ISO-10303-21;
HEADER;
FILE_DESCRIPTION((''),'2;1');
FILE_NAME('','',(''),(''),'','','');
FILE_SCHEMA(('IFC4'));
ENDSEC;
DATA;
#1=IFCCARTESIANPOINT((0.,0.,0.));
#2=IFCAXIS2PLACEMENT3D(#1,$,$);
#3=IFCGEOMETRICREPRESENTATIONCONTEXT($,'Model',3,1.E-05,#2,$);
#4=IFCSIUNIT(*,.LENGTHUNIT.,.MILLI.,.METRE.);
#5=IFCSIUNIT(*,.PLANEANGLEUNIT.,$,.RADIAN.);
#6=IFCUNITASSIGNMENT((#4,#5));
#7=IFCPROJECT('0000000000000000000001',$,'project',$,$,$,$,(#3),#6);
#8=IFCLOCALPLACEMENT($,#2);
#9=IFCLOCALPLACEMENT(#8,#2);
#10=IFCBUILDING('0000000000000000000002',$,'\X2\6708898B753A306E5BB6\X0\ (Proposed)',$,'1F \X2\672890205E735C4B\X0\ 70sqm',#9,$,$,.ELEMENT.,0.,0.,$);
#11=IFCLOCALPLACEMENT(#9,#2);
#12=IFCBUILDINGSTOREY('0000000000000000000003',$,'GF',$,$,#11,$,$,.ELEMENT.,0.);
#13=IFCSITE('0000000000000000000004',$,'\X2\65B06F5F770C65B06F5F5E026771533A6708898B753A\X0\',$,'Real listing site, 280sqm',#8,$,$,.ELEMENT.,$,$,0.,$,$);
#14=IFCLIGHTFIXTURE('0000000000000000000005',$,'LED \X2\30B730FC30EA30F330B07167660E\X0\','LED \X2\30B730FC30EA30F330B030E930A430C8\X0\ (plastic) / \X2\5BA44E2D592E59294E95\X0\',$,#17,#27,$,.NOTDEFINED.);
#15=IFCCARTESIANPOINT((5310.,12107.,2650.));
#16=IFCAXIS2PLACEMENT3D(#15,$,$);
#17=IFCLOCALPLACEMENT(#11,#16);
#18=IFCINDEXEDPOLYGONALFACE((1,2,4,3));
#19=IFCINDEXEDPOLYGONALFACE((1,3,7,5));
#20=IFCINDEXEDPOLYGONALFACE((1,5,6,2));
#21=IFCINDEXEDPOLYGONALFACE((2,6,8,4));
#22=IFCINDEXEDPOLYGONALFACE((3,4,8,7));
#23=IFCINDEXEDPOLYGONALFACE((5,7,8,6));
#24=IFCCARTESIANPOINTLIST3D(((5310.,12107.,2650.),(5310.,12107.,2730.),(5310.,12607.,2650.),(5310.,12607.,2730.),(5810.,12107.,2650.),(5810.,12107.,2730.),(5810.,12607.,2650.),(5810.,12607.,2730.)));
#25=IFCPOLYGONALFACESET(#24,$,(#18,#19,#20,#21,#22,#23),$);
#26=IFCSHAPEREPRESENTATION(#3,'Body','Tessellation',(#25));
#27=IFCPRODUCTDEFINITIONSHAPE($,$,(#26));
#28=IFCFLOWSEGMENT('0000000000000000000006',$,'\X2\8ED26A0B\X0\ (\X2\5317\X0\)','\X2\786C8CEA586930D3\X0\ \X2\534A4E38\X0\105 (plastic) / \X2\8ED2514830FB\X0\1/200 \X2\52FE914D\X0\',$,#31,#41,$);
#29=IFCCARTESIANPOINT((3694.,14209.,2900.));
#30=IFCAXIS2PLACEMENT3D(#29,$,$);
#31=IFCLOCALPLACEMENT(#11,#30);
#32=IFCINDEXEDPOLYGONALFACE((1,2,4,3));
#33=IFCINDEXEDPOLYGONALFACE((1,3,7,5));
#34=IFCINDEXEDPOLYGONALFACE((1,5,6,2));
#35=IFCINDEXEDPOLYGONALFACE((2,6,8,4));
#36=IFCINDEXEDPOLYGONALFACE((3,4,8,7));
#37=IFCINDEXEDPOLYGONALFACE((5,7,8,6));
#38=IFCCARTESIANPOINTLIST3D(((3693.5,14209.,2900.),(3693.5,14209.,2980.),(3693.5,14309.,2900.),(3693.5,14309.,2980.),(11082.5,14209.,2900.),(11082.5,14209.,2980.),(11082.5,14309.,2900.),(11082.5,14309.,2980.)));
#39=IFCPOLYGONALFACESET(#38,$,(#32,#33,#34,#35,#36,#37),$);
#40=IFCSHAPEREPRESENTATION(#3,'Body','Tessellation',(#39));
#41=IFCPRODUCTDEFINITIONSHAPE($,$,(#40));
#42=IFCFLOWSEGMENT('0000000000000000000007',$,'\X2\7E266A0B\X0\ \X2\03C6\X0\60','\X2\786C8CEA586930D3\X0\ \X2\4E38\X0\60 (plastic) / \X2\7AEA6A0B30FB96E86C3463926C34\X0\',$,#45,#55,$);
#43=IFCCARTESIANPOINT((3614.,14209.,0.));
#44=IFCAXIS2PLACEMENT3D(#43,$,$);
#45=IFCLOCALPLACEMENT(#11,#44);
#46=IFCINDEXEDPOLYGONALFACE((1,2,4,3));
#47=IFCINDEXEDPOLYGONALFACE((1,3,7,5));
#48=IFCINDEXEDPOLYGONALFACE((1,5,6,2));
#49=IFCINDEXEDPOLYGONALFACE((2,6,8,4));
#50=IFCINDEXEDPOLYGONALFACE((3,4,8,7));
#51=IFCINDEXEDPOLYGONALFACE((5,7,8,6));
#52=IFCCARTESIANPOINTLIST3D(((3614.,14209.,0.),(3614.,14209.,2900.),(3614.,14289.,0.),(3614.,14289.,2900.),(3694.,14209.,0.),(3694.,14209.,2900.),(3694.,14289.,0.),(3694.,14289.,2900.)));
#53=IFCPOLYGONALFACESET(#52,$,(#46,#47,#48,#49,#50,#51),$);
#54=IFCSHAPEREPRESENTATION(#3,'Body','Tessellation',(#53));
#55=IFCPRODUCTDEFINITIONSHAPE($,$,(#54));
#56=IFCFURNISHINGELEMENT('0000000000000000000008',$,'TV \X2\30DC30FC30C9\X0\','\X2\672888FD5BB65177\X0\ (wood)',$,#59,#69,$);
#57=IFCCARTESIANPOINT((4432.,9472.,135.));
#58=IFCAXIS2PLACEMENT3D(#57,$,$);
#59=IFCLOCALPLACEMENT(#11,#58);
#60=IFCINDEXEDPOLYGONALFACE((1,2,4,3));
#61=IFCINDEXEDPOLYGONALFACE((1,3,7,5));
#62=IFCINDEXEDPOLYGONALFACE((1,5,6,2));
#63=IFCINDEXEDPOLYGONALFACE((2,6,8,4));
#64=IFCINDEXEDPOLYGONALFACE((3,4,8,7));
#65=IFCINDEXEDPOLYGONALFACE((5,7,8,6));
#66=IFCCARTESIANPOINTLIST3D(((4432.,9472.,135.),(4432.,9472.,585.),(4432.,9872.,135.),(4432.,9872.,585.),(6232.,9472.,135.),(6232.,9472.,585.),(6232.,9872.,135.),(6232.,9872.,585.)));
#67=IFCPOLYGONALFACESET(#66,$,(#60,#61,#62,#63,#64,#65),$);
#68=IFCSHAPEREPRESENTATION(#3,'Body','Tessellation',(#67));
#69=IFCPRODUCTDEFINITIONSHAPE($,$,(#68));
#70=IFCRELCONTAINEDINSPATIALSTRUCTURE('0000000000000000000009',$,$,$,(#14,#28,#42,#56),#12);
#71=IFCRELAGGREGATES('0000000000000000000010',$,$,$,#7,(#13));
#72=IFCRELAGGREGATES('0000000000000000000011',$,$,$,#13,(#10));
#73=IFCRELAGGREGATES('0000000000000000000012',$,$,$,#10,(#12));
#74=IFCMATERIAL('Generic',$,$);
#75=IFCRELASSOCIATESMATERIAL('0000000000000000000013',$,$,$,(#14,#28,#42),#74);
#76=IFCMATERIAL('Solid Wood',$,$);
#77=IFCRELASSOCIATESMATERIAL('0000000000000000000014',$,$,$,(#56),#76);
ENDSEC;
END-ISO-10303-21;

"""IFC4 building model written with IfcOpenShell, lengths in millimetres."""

from ifc_helpers import new_model, si_unit, frame, frame_2d, origin, place, context, project, spatial, rectangle, extrude, material, element, save


model = new_model("IFC4")

# Units and contexts
model_context = context("Model", 3, precision=1e-05, world=origin())
ifc_project = project(units=[si_unit("LENGTHUNIT", "METRE", prefix="MILLI"), si_unit("PLANEANGLEUNIT", "RADIAN")], contexts=[model_context])

# Site, building, storey
site_placement = place(None, origin())
site = spatial("IfcSite", under=ifc_project, at=site_placement, Name="新潟県新潟市東区月見町", ObjectType="Real listing site, 280sqm", CompositionType="ELEMENT", RefElevation=0.0)
building_placement = place(site_placement, origin())
building = spatial("IfcBuilding", under=site, at=building_placement, Name="月見町の家 (Proposed)", ObjectType="1F 木造平屋 70sqm", CompositionType="ELEMENT", ElevationOfRefHeight=0.0, ElevationOfTerrain=0.0)
storey_placement = place(building_placement, origin())
storey = spatial("IfcBuildingStorey", under=building, at=storey_placement, Name="GF", CompositionType="ELEMENT", Elevation=0.0)

# Shared definitions
ifc_material_1 = material(Name="Solid Wood")

# Shared definitions
ifc_material_2 = material(Name="Generic")

# Light fixture
light_fixture_placement = place(storey_placement, frame((5310.0, 12107.0, 2650.0)))
element("IfcLightFixture", 1, at=light_fixture_placement, inside=storey, material=ifc_material_2, Name="LED シーリング照明", Description="LED シーリングライト (plastic) / 室中央天井", PredefinedType="NOTDEFINED", context=model_context, shape_type="SweptSolid", body=[
    extrude(rectangle(XDim=500.0, YDim=500.0, at=frame_2d((250.0, 250.0))), frame((5310.0, 12107.0, 2650.0)), (0.0, 0.0, 1.0), 80.0),
])

# Flow segments
flow_segment_1_placement = place(storey_placement, frame((3694.0, 14209.0, 2900.0)))
element("IfcFlowSegment", 2, at=flow_segment_1_placement, inside=storey, material=ifc_material_2, Name="軒樋 (北)", Description="硬質塩ビ 半丸105 (plastic) / 軒先・1/200 勾配", context=model_context, shape_type="SweptSolid", body=[
    extrude(rectangle(XDim=7389.0, YDim=100.0, at=frame_2d((3694.0, 50.0))), frame((3694.0, 14209.0, 2900.0)), (0.0, 0.0, 1.0), 80.0),
])
flow_segment_2_placement = place(storey_placement, frame((3614.0, 14209.0, 0.0)))
element("IfcFlowSegment", 3, at=flow_segment_2_placement, inside=storey, material=ifc_material_2, Name="縦樋 φ60", Description="硬質塩ビ 丸60 (plastic) / 竪樋・雨水排水", context=model_context, shape_type="SweptSolid", body=[
    extrude(rectangle(XDim=80.0, YDim=80.0, at=frame_2d((40.0, 40.0))), frame((3614.0, 14209.0, 0.0)), (0.0, 0.0, 1.0), 2900.0),
])

# Furnishing element
furnishing_placement = place(storey_placement, frame((4432.0, 9472.0, 135.0)))
element("IfcFurnishingElement", 4, at=furnishing_placement, inside=storey, material=ifc_material_1, Name="TV ボード", Description="木製家具 (wood)", context=model_context, shape_type="SweptSolid", body=[
    extrude(rectangle(XDim=1800.0, YDim=400.0, at=frame_2d((900.0, 200.0))), frame((4432.0, 9472.0, 135.0)), (0.0, 0.0, 1.0), 450.0),
])

save(model, "model.ifc")
